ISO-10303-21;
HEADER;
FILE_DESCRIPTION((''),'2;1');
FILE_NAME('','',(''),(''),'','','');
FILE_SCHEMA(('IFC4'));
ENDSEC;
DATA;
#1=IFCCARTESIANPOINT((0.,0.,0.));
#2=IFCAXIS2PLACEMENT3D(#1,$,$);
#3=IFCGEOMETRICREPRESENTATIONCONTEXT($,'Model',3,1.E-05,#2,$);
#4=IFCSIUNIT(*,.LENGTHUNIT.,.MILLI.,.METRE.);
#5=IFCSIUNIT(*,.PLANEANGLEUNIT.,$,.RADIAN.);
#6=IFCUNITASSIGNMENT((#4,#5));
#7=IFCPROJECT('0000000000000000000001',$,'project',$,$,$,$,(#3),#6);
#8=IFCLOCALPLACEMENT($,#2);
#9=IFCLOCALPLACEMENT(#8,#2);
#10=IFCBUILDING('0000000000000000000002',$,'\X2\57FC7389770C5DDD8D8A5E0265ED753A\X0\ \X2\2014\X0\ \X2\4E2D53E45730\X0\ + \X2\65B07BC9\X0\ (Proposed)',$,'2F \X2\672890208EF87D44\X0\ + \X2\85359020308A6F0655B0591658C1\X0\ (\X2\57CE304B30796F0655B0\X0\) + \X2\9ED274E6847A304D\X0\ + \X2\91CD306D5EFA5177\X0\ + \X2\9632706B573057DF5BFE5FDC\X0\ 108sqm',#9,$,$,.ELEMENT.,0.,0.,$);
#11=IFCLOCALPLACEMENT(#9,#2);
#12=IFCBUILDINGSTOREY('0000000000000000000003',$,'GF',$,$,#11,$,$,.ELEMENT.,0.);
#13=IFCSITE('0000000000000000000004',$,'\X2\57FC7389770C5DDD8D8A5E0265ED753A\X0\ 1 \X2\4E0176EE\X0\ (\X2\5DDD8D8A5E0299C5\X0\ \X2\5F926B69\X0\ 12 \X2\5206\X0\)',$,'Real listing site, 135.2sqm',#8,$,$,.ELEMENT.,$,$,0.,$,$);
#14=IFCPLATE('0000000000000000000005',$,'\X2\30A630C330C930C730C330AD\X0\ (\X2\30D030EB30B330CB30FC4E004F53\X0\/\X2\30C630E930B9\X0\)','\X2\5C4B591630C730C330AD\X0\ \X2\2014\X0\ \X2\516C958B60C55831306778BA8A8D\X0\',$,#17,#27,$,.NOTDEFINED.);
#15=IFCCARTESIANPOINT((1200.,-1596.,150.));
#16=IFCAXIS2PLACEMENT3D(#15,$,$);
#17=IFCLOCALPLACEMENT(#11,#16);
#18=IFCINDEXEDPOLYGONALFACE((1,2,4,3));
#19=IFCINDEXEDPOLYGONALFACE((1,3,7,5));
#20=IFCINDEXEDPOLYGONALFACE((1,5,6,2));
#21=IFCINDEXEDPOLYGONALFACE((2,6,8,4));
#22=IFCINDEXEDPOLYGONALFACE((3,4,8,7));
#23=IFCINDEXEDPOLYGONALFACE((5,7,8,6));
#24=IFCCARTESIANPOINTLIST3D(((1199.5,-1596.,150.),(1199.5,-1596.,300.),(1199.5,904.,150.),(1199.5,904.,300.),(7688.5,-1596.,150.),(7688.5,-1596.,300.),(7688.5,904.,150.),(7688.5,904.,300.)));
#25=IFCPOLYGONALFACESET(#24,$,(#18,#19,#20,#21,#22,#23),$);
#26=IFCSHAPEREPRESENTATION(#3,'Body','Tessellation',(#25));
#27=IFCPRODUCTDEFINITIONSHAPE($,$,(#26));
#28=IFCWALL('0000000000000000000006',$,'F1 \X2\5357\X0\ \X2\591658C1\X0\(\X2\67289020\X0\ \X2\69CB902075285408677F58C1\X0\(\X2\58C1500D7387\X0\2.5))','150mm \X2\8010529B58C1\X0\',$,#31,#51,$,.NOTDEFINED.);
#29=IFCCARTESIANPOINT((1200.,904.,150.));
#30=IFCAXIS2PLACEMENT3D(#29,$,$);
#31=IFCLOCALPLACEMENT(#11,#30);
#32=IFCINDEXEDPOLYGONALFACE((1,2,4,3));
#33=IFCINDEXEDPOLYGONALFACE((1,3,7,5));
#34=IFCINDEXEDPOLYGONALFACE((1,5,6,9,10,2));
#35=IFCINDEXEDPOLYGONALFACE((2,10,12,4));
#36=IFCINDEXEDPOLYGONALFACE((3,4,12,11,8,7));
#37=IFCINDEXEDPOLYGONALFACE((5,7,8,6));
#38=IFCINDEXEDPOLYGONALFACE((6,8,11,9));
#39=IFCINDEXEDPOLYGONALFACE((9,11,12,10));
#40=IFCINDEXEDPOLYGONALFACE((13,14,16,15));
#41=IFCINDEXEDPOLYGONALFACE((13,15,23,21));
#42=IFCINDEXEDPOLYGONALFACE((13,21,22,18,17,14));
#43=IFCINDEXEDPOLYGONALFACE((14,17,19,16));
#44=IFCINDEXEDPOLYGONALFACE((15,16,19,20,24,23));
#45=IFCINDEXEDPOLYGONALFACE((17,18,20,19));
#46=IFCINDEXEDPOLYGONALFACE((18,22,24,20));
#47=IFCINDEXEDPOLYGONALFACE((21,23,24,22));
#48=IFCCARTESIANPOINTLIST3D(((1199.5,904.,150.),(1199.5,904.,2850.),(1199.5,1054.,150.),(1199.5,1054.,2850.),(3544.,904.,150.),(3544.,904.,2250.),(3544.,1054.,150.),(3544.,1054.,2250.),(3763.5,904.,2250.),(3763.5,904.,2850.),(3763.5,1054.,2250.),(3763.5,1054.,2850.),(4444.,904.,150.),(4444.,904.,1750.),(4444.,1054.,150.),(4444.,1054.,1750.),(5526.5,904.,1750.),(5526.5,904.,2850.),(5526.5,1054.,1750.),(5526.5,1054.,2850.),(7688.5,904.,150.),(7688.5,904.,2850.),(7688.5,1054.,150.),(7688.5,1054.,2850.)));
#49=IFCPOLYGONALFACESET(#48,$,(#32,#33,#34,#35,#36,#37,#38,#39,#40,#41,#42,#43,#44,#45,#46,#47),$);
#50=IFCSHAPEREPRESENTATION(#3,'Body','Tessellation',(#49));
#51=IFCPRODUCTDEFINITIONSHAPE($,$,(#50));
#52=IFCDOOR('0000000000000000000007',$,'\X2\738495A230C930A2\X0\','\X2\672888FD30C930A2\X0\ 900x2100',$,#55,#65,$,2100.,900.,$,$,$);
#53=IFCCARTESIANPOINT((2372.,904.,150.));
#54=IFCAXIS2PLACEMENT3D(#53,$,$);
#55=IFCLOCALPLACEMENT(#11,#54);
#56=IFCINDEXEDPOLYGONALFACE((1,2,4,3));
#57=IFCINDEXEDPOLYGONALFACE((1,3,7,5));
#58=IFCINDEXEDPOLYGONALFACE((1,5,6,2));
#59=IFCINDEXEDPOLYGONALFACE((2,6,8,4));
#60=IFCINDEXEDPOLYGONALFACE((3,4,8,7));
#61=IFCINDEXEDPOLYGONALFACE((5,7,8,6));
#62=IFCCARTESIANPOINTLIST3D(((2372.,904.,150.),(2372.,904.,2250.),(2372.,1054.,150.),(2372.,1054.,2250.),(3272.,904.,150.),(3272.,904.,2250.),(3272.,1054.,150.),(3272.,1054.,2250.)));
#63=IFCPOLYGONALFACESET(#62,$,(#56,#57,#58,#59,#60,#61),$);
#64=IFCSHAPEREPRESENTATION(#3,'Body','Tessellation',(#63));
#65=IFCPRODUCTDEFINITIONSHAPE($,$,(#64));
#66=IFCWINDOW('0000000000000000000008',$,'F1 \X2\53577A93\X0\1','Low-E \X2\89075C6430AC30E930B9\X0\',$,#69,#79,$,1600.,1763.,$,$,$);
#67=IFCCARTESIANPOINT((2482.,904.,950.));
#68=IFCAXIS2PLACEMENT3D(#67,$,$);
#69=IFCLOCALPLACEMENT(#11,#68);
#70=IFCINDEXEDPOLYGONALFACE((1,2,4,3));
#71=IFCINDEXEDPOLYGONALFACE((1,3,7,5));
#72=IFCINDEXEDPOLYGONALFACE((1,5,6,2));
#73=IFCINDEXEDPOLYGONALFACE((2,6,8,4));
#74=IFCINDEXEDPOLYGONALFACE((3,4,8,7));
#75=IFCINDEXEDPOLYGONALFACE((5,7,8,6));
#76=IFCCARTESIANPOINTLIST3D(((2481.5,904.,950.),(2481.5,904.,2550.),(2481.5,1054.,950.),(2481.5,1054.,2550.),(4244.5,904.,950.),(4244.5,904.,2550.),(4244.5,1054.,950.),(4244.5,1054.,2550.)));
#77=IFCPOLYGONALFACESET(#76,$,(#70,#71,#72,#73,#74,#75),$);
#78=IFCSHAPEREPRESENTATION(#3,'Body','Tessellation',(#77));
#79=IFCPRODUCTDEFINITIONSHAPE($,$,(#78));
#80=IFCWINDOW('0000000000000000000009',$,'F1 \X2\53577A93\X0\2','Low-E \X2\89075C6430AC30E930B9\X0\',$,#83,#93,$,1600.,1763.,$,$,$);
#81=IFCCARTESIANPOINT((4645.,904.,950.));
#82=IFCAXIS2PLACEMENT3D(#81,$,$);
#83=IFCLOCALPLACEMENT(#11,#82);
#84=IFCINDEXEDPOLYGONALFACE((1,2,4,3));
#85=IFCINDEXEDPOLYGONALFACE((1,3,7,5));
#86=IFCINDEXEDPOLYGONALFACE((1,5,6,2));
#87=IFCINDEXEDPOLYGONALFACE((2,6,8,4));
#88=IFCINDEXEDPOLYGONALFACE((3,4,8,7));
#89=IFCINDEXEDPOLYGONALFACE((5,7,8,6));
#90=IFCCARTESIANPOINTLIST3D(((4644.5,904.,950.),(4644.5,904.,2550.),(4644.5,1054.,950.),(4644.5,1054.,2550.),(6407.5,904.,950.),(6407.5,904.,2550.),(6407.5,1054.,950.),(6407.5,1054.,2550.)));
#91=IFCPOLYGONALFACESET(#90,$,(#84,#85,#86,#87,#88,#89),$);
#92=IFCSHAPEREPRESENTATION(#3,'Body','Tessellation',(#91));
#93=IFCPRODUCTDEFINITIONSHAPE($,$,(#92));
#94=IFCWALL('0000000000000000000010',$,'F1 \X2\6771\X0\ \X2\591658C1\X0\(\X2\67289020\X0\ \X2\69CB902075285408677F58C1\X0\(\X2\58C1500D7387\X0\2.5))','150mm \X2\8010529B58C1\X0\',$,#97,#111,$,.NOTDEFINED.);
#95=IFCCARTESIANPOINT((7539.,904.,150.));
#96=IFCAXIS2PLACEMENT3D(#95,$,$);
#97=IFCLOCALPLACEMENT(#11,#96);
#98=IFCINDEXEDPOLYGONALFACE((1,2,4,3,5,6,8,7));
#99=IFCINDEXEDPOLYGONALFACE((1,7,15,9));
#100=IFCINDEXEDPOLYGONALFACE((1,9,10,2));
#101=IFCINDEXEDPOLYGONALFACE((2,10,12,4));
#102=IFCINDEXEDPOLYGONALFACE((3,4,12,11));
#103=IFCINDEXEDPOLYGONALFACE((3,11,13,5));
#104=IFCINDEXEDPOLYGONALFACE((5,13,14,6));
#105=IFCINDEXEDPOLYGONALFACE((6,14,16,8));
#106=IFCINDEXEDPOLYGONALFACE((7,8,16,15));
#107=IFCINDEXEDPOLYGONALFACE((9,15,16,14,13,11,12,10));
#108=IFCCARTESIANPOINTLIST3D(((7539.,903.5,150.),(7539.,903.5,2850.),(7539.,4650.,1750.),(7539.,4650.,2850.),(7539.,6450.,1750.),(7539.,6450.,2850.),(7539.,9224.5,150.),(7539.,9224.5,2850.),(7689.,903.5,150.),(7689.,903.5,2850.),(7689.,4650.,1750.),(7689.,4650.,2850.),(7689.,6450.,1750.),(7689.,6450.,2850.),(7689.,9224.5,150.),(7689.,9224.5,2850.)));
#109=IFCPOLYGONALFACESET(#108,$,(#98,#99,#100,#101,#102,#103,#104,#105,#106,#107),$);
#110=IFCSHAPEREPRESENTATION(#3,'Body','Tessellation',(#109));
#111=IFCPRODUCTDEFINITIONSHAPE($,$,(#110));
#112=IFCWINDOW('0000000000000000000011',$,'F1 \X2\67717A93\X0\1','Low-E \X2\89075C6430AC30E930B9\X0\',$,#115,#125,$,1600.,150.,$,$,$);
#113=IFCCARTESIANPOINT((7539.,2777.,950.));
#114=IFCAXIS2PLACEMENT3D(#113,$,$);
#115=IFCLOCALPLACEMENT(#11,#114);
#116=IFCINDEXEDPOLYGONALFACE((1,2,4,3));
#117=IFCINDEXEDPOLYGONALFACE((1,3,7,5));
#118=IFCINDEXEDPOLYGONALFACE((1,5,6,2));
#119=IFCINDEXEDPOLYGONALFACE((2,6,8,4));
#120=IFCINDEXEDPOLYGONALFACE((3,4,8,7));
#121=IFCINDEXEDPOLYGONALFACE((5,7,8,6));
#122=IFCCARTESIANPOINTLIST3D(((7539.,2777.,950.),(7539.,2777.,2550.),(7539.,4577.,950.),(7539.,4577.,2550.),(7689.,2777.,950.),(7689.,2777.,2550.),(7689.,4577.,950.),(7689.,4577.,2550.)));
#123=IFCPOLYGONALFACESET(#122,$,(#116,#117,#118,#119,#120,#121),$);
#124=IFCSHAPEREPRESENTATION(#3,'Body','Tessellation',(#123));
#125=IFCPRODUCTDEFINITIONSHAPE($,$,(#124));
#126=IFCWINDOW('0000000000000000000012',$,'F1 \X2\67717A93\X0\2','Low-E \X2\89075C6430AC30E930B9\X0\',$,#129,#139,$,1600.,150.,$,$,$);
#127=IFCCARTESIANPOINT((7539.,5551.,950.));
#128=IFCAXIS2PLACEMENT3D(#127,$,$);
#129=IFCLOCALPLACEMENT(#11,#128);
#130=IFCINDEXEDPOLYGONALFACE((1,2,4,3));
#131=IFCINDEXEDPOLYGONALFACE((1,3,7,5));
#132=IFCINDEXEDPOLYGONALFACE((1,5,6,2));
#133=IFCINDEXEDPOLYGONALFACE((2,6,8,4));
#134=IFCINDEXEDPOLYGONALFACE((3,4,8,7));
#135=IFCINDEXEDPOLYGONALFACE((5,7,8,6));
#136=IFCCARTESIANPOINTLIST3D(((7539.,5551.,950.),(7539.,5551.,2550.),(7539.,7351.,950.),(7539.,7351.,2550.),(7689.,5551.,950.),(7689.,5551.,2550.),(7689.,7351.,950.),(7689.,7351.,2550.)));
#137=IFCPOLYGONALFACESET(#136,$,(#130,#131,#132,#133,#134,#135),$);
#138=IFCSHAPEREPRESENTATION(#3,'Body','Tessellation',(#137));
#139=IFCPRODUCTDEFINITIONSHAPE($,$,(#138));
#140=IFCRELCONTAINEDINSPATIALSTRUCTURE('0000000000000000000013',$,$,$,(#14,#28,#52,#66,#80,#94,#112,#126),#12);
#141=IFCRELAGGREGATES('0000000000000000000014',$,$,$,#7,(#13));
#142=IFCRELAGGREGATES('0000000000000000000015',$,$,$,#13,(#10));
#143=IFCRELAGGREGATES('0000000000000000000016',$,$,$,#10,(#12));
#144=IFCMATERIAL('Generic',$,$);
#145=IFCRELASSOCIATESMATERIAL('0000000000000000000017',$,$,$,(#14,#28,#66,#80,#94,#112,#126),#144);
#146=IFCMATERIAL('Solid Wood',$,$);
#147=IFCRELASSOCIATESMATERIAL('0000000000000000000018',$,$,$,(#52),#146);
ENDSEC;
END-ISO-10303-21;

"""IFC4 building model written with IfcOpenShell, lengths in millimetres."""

from ifc_helpers import new_model, si_unit, frame, frame_2d, origin, place, context, project, spatial, rectangle, extrude, material, element, fill, save


model = new_model("IFC4")

# Units and contexts
model_context = context("Model", 3, precision=1e-05, world=origin())
ifc_project = project(units=[si_unit("LENGTHUNIT", "METRE", prefix="MILLI"), si_unit("PLANEANGLEUNIT", "RADIAN")], contexts=[model_context])

# Site, building, storey
site_placement = place(None, origin())
site = spatial("IfcSite", under=ifc_project, at=site_placement, Name="埼玉県川越市旭町 1 丁目 (川越市駅 徒歩 12 分)", ObjectType="Real listing site, 135.2sqm", CompositionType="ELEMENT", RefElevation=0.0)
building_placement = place(site_placement, origin())
building = spatial("IfcBuilding", under=site, at=building_placement, Name="埼玉県川越市旭町 — 中古地 + 新築 (Proposed)", ObjectType="2F 木造軸組 + 蔵造り漆喰外壁 (城かべ漆喰) + 黒瓦葺き + 重ね建具 + 防火地域対応 108sqm", CompositionType="ELEMENT", ElevationOfRefHeight=0.0, ElevationOfTerrain=0.0)
storey_placement = place(building_placement, origin())
storey = spatial("IfcBuildingStorey", under=building, at=storey_placement, Name="GF", CompositionType="ELEMENT", Elevation=0.0)

# Shared definitions
ifc_material_1 = material(Name="Generic")

# Plate
plate_placement = place(storey_placement, frame((1200.0, -1596.0, 150.0)))
element("IfcPlate", 1, at=plate_placement, inside=storey, material=ifc_material_1, Name="ウッドデッキ (バルコニー一体/テラス)", Description="屋外デッキ — 公開情報で確認", PredefinedType="NOTDEFINED", context=model_context, shape_type="SweptSolid", body=[
    extrude(rectangle(XDim=6489.0, YDim=2500.0, at=frame_2d((3244.0, 1250.0))), frame((1200.0, -1596.0, 150.0)), (0.0, 0.0, 1.0), 150.0),
])

# Wall, openings, door, windows
wall_1_placement = place(storey_placement, frame((1200.0, 904.0, 150.0)))
wall_1 = element("IfcWall", 2, at=wall_1_placement, inside=storey, material=ifc_material_1, Name="F1 南 外壁(木造 構造用合板壁(壁倍率2.5))", Description="150mm 耐力壁", PredefinedType="NOTDEFINED", context=model_context, shape_type="SweptSolid", body=[
    extrude(rectangle(XDim=6489.0, YDim=150.0, at=frame_2d((3244.0, 75.0))), frame((1200.0, 904.0, 150.0)), (0.0, 0.0, 1.0), 2700.0),
])
opening_1_placement = place(storey_placement, frame((2372.0, 904.0, 150.0)))
opening_1 = element("IfcOpeningElement", 3, at=opening_1_placement, cuts=wall_1, PredefinedType="NOTDEFINED", context=model_context, shape_type="SweptSolid", body=[
    extrude(rectangle(XDim=900.0, YDim=150.0, at=frame_2d((450.0, 75.0))), frame((2372.0, 904.0, 150.0)), (0.0, 0.0, 1.0), 2100.0),
])
opening_2_placement = place(storey_placement, frame((2482.0, 904.0, 950.0)))
opening_2 = element("IfcOpeningElement", 4, at=opening_2_placement, cuts=wall_1, PredefinedType="NOTDEFINED", context=model_context, shape_type="SweptSolid", body=[
    extrude(rectangle(XDim=1763.0, YDim=150.0, at=frame_2d((881.0, 75.0))), frame((2482.0, 904.0, 950.0)), (0.0, 0.0, 1.0), 1600.0),
])
opening_3_placement = place(storey_placement, frame((4645.0, 904.0, 950.0)))
opening_3 = element("IfcOpeningElement", 5, at=opening_3_placement, cuts=wall_1, PredefinedType="NOTDEFINED", context=model_context, shape_type="SweptSolid", body=[
    extrude(rectangle(XDim=1763.0, YDim=150.0, at=frame_2d((881.0, 75.0))), frame((4645.0, 904.0, 950.0)), (0.0, 0.0, 1.0), 1600.0),
])
ifc_material_2 = material(Name="Solid Wood")
door_placement = place(storey_placement, frame((2372.0, 904.0, 150.0)))
door = element("IfcDoor", 6, at=door_placement, inside=storey, material=ifc_material_2, Name="玄関ドア", Description="木製ドア 900x2100", OverallHeight=2100.0, OverallWidth=900.0, context=model_context, shape_type="SweptSolid", body=[
    extrude(rectangle(XDim=900.0, YDim=150.0, at=frame_2d((450.0, 75.0))), frame((2372.0, 904.0, 150.0)), (0.0, 0.0, 1.0), 2100.0),
])
fill(opening_1, door)
window_1_placement = place(storey_placement, frame((2482.0, 904.0, 950.0)))
window_1 = element("IfcWindow", 7, at=window_1_placement, inside=storey, material=ifc_material_1, Name="F1 南窓1", Description="Low-E 複層ガラス", OverallHeight=1600.0, OverallWidth=1763.0, context=model_context, shape_type="SweptSolid", body=[
    extrude(rectangle(XDim=1763.0, YDim=150.0, at=frame_2d((881.0, 75.0))), frame((2482.0, 904.0, 950.0)), (0.0, 0.0, 1.0), 1600.0),
])
fill(opening_2, window_1)
window_2_placement = place(storey_placement, frame((4645.0, 904.0, 950.0)))
window_2 = element("IfcWindow", 8, at=window_2_placement, inside=storey, material=ifc_material_1, Name="F1 南窓2", Description="Low-E 複層ガラス", OverallHeight=1600.0, OverallWidth=1763.0, context=model_context, shape_type="SweptSolid", body=[
    extrude(rectangle(XDim=1763.0, YDim=150.0, at=frame_2d((881.0, 75.0))), frame((4645.0, 904.0, 950.0)), (0.0, 0.0, 1.0), 1600.0),
])
fill(opening_3, window_2)

# Wall, openings, windows
wall_2_placement = place(storey_placement, frame((7539.0, 904.0, 150.0)))
wall_2 = element("IfcWall", 9, at=wall_2_placement, inside=storey, material=ifc_material_1, Name="F1 東 外壁(木造 構造用合板壁(壁倍率2.5))", Description="150mm 耐力壁", PredefinedType="NOTDEFINED", context=model_context, shape_type="SweptSolid", body=[
    extrude(rectangle(XDim=150.0, YDim=8321.0, at=frame_2d((75.0, 4160.0))), frame((7539.0, 904.0, 150.0)), (0.0, 0.0, 1.0), 2700.0),
])
opening_4_placement = place(storey_placement, frame((7539.0, 2777.0, 950.0)))
opening_4 = element("IfcOpeningElement", 10, at=opening_4_placement, cuts=wall_2, PredefinedType="NOTDEFINED", context=model_context, shape_type="SweptSolid", body=[
    extrude(rectangle(XDim=150.0, YDim=1800.0, at=frame_2d((75.0, 900.0))), frame((7539.0, 2777.0, 950.0)), (0.0, 0.0, 1.0), 1600.0),
])
opening_5_placement = place(storey_placement, frame((7539.0, 5551.0, 950.0)))
opening_5 = element("IfcOpeningElement", 11, at=opening_5_placement, cuts=wall_2, PredefinedType="NOTDEFINED", context=model_context, shape_type="SweptSolid", body=[
    extrude(rectangle(XDim=150.0, YDim=1800.0, at=frame_2d((75.0, 900.0))), frame((7539.0, 5551.0, 950.0)), (0.0, 0.0, 1.0), 1600.0),
])
window_3_placement = place(storey_placement, frame((7539.0, 2777.0, 950.0)))
window_3 = element("IfcWindow", 12, at=window_3_placement, inside=storey, material=ifc_material_1, Name="F1 東窓1", Description="Low-E 複層ガラス", OverallHeight=1600.0, OverallWidth=150.0, context=model_context, shape_type="SweptSolid", body=[
    extrude(rectangle(XDim=150.0, YDim=1800.0, at=frame_2d((75.0, 900.0))), frame((7539.0, 2777.0, 950.0)), (0.0, 0.0, 1.0), 1600.0),
])
fill(opening_4, window_3)
window_4_placement = place(storey_placement, frame((7539.0, 5551.0, 950.0)))
window_4 = element("IfcWindow", 13, at=window_4_placement, inside=storey, material=ifc_material_1, Name="F1 東窓2", Description="Low-E 複層ガラス", OverallHeight=1600.0, OverallWidth=150.0, context=model_context, shape_type="SweptSolid", body=[
    extrude(rectangle(XDim=150.0, YDim=1800.0, at=frame_2d((75.0, 900.0))), frame((7539.0, 5551.0, 950.0)), (0.0, 0.0, 1.0), 1600.0),
])
fill(opening_5, window_4)

save(model, "model.ifc")
